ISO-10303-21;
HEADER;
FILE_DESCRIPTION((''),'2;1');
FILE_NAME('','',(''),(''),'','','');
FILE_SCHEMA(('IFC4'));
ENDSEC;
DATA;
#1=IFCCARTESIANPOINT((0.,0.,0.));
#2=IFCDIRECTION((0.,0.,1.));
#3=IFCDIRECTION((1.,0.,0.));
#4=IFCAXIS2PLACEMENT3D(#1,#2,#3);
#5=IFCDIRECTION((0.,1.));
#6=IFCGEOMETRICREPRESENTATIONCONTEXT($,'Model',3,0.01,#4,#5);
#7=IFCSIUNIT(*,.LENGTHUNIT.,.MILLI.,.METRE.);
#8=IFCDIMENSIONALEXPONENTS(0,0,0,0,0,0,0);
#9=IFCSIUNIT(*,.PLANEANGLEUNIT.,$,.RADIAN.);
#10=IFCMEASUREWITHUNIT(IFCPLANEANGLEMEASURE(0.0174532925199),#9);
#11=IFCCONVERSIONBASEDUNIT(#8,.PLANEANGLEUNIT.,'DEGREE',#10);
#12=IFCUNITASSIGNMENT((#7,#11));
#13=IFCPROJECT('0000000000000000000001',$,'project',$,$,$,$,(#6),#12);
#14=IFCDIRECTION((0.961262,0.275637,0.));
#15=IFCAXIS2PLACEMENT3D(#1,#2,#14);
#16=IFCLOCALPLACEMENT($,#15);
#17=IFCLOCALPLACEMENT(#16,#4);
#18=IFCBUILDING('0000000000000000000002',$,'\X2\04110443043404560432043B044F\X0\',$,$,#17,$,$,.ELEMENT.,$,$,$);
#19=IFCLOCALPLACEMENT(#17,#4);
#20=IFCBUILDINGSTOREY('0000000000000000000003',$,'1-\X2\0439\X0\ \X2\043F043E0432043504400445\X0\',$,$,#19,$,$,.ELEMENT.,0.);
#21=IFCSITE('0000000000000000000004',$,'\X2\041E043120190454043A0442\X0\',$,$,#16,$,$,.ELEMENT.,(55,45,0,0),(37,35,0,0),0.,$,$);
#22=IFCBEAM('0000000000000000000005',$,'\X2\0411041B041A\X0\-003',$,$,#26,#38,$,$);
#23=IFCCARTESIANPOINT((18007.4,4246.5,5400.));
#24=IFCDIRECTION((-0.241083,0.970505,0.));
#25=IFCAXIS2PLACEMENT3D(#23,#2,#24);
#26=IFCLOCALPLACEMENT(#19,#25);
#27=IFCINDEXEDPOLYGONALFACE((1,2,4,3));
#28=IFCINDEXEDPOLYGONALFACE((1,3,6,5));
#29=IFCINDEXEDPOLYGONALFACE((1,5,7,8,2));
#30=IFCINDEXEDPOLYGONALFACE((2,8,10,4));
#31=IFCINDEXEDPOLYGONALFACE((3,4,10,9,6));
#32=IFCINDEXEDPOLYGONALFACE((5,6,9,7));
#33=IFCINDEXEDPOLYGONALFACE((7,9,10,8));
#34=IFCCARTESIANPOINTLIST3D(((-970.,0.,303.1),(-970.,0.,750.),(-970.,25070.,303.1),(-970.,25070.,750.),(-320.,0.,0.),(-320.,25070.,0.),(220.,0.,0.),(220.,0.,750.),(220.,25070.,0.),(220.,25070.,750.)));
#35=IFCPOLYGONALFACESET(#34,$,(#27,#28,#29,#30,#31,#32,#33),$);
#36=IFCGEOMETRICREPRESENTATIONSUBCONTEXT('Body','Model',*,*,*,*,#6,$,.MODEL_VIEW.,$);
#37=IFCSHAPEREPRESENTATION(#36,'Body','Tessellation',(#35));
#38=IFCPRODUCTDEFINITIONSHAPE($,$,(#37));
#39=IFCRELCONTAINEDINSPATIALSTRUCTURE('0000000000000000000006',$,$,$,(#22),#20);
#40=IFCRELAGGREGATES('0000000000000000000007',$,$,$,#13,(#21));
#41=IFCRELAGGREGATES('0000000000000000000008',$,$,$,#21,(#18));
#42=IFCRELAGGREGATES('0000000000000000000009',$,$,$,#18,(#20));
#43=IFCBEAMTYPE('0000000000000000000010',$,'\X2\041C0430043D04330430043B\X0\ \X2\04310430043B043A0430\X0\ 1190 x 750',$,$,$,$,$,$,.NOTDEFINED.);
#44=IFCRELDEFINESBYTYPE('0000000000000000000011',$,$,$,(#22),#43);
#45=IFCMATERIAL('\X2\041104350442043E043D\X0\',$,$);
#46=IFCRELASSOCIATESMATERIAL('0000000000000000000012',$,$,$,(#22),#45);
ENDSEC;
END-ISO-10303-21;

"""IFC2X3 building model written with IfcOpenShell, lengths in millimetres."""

from ifc_helpers import new_model, entity, si_unit, converted_unit, direction, frame, origin_with_axes, place, context, subcontext, project, spatial, polyline, outline, extrude, material, type_object, element, save


model = new_model("IFC2X3")

# Units and contexts
model_context = context("Model", 3, precision=0.01, world=origin_with_axes(), true_north=direction((0.0, 1.0)))
body_context = subcontext(model_context, "Body", "Model", "MODEL_VIEW")
ifc_project = project(units=[si_unit("LENGTHUNIT", "METRE", prefix="MILLI"), converted_unit("PLANEANGLEUNIT", "DEGREE", entity("IfcPlaneAngleMeasure", 0.0174532925199), si_unit("PLANEANGLEUNIT", "RADIAN"), dimensions=[0, 0, 0, 0, 0, 0, 0])], contexts=[model_context])

# Site, building, storey
site_placement = place(None, frame((0.0, 0.0, 0.0), z_axis=(0.0, 0.0, 1.0), x_axis=(0.961262, 0.275637, 0.0)))
site = spatial("IfcSite", under=ifc_project, at=site_placement, Name="Об’єкт", CompositionType="ELEMENT", RefLatitude=(55, 45, 0, 0), RefLongitude=(37, 35, 0, 0), RefElevation=0.0)
building_placement = place(site_placement, origin_with_axes())
building = spatial("IfcBuilding", under=site, at=building_placement, Name="Будівля", CompositionType="ELEMENT")
storey_placement = place(building_placement, origin_with_axes())
storey = spatial("IfcBuildingStorey", under=building, at=storey_placement, Name="1-й поверх", CompositionType="ELEMENT", Elevation=0.0)

# Beam
ifc_material_1 = material(Name="Бетон")
beam_type = type_object("IfcBeamType", Name="Мангал балка 1190 x 750", PredefinedType="NOTDEFINED")
beam_placement = place(storey_placement, frame((18007.4, 4246.5, 5400.0), z_axis=(0.0, 0.0, 1.0), x_axis=(-0.241083, 0.970505, 0.0)))
element("IfcBeam", 1, at=beam_placement, inside=storey, type_object=beam_type, material=ifc_material_1, Name="БЛК-003", context=body_context, shape_type="SweptSolid", body=[
    extrude(outline(polyline([(220.0, 750.0), (-970.0, 750.0), (-970.0, 303.1), (-320.0, 0.0), (220.0, 0.0), (220.0, 750.0)])), frame((0.0, 25070.0, 0.0), z_axis=(0.0, -1.0, 0.0), x_axis=(1.0, 0.0, 0.0)), (0.0, 0.0, 1.0), 25070.0),
])

save(model, "model.ifc")
